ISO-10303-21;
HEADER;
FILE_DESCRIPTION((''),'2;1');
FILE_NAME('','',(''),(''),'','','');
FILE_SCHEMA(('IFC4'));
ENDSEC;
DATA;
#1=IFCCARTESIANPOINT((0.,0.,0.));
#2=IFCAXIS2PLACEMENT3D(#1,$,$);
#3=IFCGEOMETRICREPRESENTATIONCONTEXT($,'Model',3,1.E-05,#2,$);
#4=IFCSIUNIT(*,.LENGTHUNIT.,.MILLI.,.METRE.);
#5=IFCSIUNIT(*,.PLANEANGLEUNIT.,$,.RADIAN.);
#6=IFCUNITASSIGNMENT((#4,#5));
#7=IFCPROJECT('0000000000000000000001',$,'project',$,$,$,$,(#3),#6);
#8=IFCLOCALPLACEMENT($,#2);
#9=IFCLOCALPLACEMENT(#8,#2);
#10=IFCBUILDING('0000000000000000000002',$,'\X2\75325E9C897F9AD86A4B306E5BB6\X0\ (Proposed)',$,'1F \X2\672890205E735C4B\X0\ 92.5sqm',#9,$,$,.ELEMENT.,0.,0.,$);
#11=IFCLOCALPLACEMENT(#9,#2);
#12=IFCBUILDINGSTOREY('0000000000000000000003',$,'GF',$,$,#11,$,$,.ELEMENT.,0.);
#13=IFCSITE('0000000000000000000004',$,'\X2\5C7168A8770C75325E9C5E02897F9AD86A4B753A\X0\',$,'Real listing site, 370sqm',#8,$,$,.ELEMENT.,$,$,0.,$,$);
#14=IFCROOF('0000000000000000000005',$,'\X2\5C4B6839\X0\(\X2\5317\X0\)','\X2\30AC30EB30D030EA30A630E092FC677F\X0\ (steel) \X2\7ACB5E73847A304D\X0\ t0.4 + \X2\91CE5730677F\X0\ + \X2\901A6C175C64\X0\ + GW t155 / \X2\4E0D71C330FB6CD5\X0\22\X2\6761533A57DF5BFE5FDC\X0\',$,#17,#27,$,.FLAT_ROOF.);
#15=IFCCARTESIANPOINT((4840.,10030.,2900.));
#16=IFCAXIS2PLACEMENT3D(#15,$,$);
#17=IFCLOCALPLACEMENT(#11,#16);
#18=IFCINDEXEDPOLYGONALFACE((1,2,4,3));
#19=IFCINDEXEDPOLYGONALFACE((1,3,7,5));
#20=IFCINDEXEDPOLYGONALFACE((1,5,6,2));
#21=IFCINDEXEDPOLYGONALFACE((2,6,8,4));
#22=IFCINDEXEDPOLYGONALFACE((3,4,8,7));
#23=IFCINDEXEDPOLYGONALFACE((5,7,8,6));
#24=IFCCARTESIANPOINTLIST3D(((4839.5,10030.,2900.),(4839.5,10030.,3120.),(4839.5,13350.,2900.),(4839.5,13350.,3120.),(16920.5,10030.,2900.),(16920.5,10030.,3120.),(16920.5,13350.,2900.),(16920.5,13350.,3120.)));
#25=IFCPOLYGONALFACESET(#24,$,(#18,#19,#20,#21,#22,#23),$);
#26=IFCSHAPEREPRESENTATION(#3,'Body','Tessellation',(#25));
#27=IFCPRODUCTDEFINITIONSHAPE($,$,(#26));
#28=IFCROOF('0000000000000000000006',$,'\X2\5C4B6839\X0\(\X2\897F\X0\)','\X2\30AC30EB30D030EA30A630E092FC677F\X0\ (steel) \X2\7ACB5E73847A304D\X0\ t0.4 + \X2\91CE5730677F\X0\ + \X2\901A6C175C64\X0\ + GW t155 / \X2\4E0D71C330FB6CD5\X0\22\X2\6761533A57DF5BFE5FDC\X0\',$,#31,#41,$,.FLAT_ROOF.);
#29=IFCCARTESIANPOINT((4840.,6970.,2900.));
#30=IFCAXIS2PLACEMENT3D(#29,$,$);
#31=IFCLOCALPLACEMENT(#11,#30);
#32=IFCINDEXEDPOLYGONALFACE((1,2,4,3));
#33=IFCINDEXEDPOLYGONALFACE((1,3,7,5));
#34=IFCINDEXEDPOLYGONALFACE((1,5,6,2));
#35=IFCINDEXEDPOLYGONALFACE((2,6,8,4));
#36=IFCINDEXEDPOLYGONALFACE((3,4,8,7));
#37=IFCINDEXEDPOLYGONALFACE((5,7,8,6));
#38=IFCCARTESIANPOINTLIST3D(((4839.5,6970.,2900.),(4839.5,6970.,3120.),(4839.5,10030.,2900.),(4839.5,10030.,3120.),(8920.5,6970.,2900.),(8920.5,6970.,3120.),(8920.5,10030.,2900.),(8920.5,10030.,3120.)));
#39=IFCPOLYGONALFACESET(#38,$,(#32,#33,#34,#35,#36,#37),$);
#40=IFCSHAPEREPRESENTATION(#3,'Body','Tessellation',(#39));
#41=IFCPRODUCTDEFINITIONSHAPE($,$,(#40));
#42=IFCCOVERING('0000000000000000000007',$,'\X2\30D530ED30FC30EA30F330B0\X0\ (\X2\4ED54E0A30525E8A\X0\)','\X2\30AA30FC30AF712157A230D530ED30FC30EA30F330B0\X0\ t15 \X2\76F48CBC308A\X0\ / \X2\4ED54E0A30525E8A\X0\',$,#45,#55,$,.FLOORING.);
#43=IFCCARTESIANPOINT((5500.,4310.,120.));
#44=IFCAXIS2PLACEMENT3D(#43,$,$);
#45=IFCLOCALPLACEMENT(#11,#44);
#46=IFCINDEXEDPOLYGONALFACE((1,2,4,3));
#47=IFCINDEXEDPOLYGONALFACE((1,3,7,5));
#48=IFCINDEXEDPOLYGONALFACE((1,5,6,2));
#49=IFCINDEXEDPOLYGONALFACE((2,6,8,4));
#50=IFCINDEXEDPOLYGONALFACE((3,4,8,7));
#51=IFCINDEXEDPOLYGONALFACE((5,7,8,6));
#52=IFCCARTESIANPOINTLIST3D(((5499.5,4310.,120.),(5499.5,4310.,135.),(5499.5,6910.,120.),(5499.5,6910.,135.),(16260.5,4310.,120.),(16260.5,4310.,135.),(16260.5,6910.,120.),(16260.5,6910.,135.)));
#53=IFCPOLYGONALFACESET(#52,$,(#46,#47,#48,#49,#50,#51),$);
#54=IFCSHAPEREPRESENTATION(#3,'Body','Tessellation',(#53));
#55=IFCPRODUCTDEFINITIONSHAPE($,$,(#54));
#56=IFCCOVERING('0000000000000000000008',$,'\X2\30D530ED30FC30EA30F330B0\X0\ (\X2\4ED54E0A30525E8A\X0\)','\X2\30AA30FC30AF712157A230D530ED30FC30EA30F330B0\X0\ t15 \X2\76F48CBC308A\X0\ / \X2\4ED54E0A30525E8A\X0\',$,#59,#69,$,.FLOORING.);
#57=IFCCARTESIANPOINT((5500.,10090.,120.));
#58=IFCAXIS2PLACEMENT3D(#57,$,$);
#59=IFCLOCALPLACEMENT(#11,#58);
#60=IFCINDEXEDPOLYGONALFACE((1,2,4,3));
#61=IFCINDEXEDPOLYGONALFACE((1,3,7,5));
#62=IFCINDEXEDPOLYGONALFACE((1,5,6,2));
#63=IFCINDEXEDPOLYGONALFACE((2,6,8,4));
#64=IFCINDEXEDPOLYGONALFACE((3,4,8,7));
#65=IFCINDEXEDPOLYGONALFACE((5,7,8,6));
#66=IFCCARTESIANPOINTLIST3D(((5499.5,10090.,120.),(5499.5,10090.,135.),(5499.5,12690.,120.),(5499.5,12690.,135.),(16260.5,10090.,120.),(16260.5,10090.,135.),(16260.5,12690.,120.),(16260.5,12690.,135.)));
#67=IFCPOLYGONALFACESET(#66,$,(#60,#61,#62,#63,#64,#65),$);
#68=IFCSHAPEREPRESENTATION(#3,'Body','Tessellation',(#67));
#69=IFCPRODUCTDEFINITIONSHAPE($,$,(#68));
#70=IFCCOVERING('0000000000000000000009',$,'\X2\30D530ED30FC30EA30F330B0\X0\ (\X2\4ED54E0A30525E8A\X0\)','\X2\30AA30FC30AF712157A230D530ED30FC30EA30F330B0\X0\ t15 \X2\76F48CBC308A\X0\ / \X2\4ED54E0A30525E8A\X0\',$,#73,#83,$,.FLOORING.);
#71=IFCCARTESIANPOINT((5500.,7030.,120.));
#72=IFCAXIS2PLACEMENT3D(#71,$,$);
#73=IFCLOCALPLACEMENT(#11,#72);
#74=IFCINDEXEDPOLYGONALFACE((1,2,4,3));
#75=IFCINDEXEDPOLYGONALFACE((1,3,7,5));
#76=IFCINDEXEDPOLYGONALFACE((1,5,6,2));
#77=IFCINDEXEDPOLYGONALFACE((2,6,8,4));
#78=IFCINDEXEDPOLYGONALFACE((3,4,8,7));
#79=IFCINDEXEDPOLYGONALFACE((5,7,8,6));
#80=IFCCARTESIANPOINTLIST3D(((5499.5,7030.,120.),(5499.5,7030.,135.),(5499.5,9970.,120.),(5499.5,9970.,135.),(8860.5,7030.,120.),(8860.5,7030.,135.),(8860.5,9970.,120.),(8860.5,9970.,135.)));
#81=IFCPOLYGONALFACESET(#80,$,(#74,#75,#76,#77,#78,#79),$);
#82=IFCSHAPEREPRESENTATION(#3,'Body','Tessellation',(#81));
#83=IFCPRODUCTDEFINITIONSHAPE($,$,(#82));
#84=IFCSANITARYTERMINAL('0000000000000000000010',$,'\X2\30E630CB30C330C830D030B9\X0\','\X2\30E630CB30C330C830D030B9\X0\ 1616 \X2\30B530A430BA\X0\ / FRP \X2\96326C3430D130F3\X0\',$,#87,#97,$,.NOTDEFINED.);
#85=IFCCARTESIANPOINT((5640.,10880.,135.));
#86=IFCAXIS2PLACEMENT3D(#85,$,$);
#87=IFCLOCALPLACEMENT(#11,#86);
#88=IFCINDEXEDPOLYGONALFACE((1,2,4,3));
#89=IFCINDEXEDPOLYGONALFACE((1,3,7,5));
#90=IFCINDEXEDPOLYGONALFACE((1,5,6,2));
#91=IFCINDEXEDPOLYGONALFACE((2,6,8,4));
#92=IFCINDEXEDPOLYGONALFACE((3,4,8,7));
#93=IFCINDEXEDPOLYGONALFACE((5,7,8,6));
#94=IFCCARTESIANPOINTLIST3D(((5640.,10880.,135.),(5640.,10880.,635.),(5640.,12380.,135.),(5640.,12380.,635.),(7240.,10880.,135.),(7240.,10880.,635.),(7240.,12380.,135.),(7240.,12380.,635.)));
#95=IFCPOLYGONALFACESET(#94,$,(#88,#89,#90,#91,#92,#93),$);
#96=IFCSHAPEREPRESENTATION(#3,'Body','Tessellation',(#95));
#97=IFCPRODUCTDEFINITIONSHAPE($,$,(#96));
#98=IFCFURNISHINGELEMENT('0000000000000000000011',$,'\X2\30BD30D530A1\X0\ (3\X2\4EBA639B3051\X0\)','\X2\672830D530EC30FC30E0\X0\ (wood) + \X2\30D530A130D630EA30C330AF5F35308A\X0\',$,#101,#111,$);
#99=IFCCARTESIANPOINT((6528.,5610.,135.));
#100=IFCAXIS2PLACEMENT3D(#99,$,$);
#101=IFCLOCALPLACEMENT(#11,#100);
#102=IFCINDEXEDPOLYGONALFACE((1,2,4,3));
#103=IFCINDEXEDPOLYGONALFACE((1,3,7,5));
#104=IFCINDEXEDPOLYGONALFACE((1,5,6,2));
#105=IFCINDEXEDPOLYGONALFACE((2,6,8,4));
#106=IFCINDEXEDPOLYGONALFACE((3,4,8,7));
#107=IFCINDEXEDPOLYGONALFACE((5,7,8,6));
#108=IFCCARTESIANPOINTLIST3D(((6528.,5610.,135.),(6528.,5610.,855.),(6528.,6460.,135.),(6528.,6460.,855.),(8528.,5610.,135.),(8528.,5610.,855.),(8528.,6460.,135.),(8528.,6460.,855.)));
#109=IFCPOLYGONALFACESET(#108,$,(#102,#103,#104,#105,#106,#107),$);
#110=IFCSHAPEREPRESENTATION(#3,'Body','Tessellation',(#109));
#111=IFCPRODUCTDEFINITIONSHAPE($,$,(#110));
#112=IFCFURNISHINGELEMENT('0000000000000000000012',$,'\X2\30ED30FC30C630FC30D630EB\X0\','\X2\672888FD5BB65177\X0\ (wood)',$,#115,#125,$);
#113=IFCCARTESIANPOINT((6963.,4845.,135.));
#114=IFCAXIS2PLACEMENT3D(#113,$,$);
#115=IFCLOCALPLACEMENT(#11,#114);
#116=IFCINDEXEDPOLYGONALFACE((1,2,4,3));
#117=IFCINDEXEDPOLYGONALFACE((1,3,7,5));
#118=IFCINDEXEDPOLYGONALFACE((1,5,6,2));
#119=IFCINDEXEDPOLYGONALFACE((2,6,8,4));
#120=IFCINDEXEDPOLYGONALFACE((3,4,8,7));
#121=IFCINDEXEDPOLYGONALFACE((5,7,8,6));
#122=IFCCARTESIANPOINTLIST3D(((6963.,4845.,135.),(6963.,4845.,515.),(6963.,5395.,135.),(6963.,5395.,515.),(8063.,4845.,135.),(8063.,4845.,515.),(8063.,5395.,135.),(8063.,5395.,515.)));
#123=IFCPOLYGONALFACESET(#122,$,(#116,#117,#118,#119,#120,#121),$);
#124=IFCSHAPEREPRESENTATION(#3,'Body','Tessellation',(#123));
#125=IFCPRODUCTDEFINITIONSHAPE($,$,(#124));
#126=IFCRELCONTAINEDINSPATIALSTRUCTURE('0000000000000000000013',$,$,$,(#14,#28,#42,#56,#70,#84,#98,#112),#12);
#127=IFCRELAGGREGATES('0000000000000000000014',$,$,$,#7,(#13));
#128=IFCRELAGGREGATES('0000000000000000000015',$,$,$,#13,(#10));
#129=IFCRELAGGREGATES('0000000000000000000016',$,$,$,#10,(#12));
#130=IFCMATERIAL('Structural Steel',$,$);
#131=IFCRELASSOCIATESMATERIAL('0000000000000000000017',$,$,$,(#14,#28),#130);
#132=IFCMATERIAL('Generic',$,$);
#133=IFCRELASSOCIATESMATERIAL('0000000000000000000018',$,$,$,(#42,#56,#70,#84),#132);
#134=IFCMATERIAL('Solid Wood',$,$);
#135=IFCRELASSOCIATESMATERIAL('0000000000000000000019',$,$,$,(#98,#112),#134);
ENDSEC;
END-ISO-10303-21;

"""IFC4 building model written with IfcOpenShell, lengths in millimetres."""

from ifc_helpers import new_model, si_unit, frame, frame_2d, origin, place, context, project, spatial, rectangle, extrude, material, element, save


model = new_model("IFC4")

# Units and contexts
model_context = context("Model", 3, precision=1e-05, world=origin())
ifc_project = project(units=[si_unit("LENGTHUNIT", "METRE", prefix="MILLI"), si_unit("PLANEANGLEUNIT", "RADIAN")], contexts=[model_context])

# Site, building, storey
site_placement = place(None, origin())
site = spatial("IfcSite", under=ifc_project, at=site_placement, Name="山梨県甲府市西高橋町", ObjectType="Real listing site, 370sqm", CompositionType="ELEMENT", RefElevation=0.0)
building_placement = place(site_placement, origin())
building = spatial("IfcBuilding", under=site, at=building_placement, Name="甲府西高橋の家 (Proposed)", ObjectType="1F 木造平屋 92.5sqm", CompositionType="ELEMENT", ElevationOfRefHeight=0.0, ElevationOfTerrain=0.0)
storey_placement = place(building_placement, origin())
storey = spatial("IfcBuildingStorey", under=building, at=storey_placement, Name="GF", CompositionType="ELEMENT", Elevation=0.0)

# Shared definitions
ifc_material_1 = material(Name="Solid Wood")

# Roofs
ifc_material_2 = material(Name="Structural Steel")
roof_1_placement = place(storey_placement, frame((4840.0, 10030.0, 2900.0)))
element("IfcRoof", 1, at=roof_1_placement, inside=storey, material=ifc_material_2, Name="屋根(北)", Description="ガルバリウム鋼板 (steel) 立平葺き t0.4 + 野地板 + 通気層 + GW t155 / 不燃・法22条区域対応", PredefinedType="FLAT_ROOF", context=model_context, shape_type="SweptSolid", body=[
    extrude(rectangle(XDim=12081.0, YDim=3320.0, at=frame_2d((6040.0, 1660.0))), frame((4840.0, 10030.0, 2900.0)), (0.0, 0.0, 1.0), 220.0),
])
roof_2_placement = place(storey_placement, frame((4840.0, 6970.0, 2900.0)))
element("IfcRoof", 2, at=roof_2_placement, inside=storey, material=ifc_material_2, Name="屋根(西)", Description="ガルバリウム鋼板 (steel) 立平葺き t0.4 + 野地板 + 通気層 + GW t155 / 不燃・法22条区域対応", PredefinedType="FLAT_ROOF", context=model_context, shape_type="SweptSolid", body=[
    extrude(rectangle(XDim=4081.0, YDim=3060.0, at=frame_2d((2040.0, 1530.0))), frame((4840.0, 6970.0, 2900.0)), (0.0, 0.0, 1.0), 220.0),
])

# Coverings
ifc_material_3 = material(Name="Generic")
covering_1_placement = place(storey_placement, frame((5500.0, 4310.0, 120.0)))
element("IfcCovering", 3, at=covering_1_placement, inside=storey, material=ifc_material_3, Name="フローリング (仕上げ床)", Description="オーク無垢フローリング t15 直貼り / 仕上げ床", PredefinedType="FLOORING", context=model_context, shape_type="SweptSolid", body=[
    extrude(rectangle(XDim=10761.0, YDim=2600.0, at=frame_2d((5380.0, 1300.0))), frame((5500.0, 4310.0, 120.0)), (0.0, 0.0, 1.0), 15.0),
])
covering_2_placement = place(storey_placement, frame((5500.0, 10090.0, 120.0)))
element("IfcCovering", 4, at=covering_2_placement, inside=storey, material=ifc_material_3, Name="フローリング (仕上げ床)", Description="オーク無垢フローリング t15 直貼り / 仕上げ床", PredefinedType="FLOORING", context=model_context, shape_type="SweptSolid", body=[
    extrude(rectangle(XDim=10761.0, YDim=2600.0, at=frame_2d((5380.0, 1300.0))), frame((5500.0, 10090.0, 120.0)), (0.0, 0.0, 1.0), 15.0),
])
covering_3_placement = place(storey_placement, frame((5500.0, 7030.0, 120.0)))
element("IfcCovering", 5, at=covering_3_placement, inside=storey, material=ifc_material_3, Name="フローリング (仕上げ床)", Description="オーク無垢フローリング t15 直貼り / 仕上げ床", PredefinedType="FLOORING", context=model_context, shape_type="SweptSolid", body=[
    extrude(rectangle(XDim=3361.0, YDim=2940.0, at=frame_2d((1680.0, 1470.0))), frame((5500.0, 7030.0, 120.0)), (0.0, 0.0, 1.0), 15.0),
])

# Sanitary terminal
sanitary_terminal_placement = place(storey_placement, frame((5640.0, 10880.0, 135.0)))
element("IfcSanitaryTerminal", 6, at=sanitary_terminal_placement, inside=storey, material=ifc_material_3, Name="ユニットバス", Description="ユニットバス 1616 サイズ / FRP 防水パン", PredefinedType="NOTDEFINED", context=model_context, shape_type="SweptSolid", body=[
    extrude(rectangle(XDim=1600.0, YDim=1500.0, at=frame_2d((800.0, 750.0))), frame((5640.0, 10880.0, 135.0)), (0.0, 0.0, 1.0), 500.0),
])

# Furnishing elements
furnishing_1_placement = place(storey_placement, frame((6528.0, 5610.0, 135.0)))
element("IfcFurnishingElement", 7, at=furnishing_1_placement, inside=storey, material=ifc_material_1, Name="ソファ (3人掛け)", Description="木フレーム (wood) + ファブリック張り", context=model_context, shape_type="SweptSolid", body=[
    extrude(rectangle(XDim=2000.0, YDim=850.0, at=frame_2d((1000.0, 425.0))), frame((6528.0, 5610.0, 135.0)), (0.0, 0.0, 1.0), 720.0),
])
furnishing_2_placement = place(storey_placement, frame((6963.0, 4845.0, 135.0)))
element("IfcFurnishingElement", 8, at=furnishing_2_placement, inside=storey, material=ifc_material_1, Name="ローテーブル", Description="木製家具 (wood)", context=model_context, shape_type="SweptSolid", body=[
    extrude(rectangle(XDim=1100.0, YDim=550.0, at=frame_2d((550.0, 275.0))), frame((6963.0, 4845.0, 135.0)), (0.0, 0.0, 1.0), 380.0),
])

save(model, "model.ifc")
